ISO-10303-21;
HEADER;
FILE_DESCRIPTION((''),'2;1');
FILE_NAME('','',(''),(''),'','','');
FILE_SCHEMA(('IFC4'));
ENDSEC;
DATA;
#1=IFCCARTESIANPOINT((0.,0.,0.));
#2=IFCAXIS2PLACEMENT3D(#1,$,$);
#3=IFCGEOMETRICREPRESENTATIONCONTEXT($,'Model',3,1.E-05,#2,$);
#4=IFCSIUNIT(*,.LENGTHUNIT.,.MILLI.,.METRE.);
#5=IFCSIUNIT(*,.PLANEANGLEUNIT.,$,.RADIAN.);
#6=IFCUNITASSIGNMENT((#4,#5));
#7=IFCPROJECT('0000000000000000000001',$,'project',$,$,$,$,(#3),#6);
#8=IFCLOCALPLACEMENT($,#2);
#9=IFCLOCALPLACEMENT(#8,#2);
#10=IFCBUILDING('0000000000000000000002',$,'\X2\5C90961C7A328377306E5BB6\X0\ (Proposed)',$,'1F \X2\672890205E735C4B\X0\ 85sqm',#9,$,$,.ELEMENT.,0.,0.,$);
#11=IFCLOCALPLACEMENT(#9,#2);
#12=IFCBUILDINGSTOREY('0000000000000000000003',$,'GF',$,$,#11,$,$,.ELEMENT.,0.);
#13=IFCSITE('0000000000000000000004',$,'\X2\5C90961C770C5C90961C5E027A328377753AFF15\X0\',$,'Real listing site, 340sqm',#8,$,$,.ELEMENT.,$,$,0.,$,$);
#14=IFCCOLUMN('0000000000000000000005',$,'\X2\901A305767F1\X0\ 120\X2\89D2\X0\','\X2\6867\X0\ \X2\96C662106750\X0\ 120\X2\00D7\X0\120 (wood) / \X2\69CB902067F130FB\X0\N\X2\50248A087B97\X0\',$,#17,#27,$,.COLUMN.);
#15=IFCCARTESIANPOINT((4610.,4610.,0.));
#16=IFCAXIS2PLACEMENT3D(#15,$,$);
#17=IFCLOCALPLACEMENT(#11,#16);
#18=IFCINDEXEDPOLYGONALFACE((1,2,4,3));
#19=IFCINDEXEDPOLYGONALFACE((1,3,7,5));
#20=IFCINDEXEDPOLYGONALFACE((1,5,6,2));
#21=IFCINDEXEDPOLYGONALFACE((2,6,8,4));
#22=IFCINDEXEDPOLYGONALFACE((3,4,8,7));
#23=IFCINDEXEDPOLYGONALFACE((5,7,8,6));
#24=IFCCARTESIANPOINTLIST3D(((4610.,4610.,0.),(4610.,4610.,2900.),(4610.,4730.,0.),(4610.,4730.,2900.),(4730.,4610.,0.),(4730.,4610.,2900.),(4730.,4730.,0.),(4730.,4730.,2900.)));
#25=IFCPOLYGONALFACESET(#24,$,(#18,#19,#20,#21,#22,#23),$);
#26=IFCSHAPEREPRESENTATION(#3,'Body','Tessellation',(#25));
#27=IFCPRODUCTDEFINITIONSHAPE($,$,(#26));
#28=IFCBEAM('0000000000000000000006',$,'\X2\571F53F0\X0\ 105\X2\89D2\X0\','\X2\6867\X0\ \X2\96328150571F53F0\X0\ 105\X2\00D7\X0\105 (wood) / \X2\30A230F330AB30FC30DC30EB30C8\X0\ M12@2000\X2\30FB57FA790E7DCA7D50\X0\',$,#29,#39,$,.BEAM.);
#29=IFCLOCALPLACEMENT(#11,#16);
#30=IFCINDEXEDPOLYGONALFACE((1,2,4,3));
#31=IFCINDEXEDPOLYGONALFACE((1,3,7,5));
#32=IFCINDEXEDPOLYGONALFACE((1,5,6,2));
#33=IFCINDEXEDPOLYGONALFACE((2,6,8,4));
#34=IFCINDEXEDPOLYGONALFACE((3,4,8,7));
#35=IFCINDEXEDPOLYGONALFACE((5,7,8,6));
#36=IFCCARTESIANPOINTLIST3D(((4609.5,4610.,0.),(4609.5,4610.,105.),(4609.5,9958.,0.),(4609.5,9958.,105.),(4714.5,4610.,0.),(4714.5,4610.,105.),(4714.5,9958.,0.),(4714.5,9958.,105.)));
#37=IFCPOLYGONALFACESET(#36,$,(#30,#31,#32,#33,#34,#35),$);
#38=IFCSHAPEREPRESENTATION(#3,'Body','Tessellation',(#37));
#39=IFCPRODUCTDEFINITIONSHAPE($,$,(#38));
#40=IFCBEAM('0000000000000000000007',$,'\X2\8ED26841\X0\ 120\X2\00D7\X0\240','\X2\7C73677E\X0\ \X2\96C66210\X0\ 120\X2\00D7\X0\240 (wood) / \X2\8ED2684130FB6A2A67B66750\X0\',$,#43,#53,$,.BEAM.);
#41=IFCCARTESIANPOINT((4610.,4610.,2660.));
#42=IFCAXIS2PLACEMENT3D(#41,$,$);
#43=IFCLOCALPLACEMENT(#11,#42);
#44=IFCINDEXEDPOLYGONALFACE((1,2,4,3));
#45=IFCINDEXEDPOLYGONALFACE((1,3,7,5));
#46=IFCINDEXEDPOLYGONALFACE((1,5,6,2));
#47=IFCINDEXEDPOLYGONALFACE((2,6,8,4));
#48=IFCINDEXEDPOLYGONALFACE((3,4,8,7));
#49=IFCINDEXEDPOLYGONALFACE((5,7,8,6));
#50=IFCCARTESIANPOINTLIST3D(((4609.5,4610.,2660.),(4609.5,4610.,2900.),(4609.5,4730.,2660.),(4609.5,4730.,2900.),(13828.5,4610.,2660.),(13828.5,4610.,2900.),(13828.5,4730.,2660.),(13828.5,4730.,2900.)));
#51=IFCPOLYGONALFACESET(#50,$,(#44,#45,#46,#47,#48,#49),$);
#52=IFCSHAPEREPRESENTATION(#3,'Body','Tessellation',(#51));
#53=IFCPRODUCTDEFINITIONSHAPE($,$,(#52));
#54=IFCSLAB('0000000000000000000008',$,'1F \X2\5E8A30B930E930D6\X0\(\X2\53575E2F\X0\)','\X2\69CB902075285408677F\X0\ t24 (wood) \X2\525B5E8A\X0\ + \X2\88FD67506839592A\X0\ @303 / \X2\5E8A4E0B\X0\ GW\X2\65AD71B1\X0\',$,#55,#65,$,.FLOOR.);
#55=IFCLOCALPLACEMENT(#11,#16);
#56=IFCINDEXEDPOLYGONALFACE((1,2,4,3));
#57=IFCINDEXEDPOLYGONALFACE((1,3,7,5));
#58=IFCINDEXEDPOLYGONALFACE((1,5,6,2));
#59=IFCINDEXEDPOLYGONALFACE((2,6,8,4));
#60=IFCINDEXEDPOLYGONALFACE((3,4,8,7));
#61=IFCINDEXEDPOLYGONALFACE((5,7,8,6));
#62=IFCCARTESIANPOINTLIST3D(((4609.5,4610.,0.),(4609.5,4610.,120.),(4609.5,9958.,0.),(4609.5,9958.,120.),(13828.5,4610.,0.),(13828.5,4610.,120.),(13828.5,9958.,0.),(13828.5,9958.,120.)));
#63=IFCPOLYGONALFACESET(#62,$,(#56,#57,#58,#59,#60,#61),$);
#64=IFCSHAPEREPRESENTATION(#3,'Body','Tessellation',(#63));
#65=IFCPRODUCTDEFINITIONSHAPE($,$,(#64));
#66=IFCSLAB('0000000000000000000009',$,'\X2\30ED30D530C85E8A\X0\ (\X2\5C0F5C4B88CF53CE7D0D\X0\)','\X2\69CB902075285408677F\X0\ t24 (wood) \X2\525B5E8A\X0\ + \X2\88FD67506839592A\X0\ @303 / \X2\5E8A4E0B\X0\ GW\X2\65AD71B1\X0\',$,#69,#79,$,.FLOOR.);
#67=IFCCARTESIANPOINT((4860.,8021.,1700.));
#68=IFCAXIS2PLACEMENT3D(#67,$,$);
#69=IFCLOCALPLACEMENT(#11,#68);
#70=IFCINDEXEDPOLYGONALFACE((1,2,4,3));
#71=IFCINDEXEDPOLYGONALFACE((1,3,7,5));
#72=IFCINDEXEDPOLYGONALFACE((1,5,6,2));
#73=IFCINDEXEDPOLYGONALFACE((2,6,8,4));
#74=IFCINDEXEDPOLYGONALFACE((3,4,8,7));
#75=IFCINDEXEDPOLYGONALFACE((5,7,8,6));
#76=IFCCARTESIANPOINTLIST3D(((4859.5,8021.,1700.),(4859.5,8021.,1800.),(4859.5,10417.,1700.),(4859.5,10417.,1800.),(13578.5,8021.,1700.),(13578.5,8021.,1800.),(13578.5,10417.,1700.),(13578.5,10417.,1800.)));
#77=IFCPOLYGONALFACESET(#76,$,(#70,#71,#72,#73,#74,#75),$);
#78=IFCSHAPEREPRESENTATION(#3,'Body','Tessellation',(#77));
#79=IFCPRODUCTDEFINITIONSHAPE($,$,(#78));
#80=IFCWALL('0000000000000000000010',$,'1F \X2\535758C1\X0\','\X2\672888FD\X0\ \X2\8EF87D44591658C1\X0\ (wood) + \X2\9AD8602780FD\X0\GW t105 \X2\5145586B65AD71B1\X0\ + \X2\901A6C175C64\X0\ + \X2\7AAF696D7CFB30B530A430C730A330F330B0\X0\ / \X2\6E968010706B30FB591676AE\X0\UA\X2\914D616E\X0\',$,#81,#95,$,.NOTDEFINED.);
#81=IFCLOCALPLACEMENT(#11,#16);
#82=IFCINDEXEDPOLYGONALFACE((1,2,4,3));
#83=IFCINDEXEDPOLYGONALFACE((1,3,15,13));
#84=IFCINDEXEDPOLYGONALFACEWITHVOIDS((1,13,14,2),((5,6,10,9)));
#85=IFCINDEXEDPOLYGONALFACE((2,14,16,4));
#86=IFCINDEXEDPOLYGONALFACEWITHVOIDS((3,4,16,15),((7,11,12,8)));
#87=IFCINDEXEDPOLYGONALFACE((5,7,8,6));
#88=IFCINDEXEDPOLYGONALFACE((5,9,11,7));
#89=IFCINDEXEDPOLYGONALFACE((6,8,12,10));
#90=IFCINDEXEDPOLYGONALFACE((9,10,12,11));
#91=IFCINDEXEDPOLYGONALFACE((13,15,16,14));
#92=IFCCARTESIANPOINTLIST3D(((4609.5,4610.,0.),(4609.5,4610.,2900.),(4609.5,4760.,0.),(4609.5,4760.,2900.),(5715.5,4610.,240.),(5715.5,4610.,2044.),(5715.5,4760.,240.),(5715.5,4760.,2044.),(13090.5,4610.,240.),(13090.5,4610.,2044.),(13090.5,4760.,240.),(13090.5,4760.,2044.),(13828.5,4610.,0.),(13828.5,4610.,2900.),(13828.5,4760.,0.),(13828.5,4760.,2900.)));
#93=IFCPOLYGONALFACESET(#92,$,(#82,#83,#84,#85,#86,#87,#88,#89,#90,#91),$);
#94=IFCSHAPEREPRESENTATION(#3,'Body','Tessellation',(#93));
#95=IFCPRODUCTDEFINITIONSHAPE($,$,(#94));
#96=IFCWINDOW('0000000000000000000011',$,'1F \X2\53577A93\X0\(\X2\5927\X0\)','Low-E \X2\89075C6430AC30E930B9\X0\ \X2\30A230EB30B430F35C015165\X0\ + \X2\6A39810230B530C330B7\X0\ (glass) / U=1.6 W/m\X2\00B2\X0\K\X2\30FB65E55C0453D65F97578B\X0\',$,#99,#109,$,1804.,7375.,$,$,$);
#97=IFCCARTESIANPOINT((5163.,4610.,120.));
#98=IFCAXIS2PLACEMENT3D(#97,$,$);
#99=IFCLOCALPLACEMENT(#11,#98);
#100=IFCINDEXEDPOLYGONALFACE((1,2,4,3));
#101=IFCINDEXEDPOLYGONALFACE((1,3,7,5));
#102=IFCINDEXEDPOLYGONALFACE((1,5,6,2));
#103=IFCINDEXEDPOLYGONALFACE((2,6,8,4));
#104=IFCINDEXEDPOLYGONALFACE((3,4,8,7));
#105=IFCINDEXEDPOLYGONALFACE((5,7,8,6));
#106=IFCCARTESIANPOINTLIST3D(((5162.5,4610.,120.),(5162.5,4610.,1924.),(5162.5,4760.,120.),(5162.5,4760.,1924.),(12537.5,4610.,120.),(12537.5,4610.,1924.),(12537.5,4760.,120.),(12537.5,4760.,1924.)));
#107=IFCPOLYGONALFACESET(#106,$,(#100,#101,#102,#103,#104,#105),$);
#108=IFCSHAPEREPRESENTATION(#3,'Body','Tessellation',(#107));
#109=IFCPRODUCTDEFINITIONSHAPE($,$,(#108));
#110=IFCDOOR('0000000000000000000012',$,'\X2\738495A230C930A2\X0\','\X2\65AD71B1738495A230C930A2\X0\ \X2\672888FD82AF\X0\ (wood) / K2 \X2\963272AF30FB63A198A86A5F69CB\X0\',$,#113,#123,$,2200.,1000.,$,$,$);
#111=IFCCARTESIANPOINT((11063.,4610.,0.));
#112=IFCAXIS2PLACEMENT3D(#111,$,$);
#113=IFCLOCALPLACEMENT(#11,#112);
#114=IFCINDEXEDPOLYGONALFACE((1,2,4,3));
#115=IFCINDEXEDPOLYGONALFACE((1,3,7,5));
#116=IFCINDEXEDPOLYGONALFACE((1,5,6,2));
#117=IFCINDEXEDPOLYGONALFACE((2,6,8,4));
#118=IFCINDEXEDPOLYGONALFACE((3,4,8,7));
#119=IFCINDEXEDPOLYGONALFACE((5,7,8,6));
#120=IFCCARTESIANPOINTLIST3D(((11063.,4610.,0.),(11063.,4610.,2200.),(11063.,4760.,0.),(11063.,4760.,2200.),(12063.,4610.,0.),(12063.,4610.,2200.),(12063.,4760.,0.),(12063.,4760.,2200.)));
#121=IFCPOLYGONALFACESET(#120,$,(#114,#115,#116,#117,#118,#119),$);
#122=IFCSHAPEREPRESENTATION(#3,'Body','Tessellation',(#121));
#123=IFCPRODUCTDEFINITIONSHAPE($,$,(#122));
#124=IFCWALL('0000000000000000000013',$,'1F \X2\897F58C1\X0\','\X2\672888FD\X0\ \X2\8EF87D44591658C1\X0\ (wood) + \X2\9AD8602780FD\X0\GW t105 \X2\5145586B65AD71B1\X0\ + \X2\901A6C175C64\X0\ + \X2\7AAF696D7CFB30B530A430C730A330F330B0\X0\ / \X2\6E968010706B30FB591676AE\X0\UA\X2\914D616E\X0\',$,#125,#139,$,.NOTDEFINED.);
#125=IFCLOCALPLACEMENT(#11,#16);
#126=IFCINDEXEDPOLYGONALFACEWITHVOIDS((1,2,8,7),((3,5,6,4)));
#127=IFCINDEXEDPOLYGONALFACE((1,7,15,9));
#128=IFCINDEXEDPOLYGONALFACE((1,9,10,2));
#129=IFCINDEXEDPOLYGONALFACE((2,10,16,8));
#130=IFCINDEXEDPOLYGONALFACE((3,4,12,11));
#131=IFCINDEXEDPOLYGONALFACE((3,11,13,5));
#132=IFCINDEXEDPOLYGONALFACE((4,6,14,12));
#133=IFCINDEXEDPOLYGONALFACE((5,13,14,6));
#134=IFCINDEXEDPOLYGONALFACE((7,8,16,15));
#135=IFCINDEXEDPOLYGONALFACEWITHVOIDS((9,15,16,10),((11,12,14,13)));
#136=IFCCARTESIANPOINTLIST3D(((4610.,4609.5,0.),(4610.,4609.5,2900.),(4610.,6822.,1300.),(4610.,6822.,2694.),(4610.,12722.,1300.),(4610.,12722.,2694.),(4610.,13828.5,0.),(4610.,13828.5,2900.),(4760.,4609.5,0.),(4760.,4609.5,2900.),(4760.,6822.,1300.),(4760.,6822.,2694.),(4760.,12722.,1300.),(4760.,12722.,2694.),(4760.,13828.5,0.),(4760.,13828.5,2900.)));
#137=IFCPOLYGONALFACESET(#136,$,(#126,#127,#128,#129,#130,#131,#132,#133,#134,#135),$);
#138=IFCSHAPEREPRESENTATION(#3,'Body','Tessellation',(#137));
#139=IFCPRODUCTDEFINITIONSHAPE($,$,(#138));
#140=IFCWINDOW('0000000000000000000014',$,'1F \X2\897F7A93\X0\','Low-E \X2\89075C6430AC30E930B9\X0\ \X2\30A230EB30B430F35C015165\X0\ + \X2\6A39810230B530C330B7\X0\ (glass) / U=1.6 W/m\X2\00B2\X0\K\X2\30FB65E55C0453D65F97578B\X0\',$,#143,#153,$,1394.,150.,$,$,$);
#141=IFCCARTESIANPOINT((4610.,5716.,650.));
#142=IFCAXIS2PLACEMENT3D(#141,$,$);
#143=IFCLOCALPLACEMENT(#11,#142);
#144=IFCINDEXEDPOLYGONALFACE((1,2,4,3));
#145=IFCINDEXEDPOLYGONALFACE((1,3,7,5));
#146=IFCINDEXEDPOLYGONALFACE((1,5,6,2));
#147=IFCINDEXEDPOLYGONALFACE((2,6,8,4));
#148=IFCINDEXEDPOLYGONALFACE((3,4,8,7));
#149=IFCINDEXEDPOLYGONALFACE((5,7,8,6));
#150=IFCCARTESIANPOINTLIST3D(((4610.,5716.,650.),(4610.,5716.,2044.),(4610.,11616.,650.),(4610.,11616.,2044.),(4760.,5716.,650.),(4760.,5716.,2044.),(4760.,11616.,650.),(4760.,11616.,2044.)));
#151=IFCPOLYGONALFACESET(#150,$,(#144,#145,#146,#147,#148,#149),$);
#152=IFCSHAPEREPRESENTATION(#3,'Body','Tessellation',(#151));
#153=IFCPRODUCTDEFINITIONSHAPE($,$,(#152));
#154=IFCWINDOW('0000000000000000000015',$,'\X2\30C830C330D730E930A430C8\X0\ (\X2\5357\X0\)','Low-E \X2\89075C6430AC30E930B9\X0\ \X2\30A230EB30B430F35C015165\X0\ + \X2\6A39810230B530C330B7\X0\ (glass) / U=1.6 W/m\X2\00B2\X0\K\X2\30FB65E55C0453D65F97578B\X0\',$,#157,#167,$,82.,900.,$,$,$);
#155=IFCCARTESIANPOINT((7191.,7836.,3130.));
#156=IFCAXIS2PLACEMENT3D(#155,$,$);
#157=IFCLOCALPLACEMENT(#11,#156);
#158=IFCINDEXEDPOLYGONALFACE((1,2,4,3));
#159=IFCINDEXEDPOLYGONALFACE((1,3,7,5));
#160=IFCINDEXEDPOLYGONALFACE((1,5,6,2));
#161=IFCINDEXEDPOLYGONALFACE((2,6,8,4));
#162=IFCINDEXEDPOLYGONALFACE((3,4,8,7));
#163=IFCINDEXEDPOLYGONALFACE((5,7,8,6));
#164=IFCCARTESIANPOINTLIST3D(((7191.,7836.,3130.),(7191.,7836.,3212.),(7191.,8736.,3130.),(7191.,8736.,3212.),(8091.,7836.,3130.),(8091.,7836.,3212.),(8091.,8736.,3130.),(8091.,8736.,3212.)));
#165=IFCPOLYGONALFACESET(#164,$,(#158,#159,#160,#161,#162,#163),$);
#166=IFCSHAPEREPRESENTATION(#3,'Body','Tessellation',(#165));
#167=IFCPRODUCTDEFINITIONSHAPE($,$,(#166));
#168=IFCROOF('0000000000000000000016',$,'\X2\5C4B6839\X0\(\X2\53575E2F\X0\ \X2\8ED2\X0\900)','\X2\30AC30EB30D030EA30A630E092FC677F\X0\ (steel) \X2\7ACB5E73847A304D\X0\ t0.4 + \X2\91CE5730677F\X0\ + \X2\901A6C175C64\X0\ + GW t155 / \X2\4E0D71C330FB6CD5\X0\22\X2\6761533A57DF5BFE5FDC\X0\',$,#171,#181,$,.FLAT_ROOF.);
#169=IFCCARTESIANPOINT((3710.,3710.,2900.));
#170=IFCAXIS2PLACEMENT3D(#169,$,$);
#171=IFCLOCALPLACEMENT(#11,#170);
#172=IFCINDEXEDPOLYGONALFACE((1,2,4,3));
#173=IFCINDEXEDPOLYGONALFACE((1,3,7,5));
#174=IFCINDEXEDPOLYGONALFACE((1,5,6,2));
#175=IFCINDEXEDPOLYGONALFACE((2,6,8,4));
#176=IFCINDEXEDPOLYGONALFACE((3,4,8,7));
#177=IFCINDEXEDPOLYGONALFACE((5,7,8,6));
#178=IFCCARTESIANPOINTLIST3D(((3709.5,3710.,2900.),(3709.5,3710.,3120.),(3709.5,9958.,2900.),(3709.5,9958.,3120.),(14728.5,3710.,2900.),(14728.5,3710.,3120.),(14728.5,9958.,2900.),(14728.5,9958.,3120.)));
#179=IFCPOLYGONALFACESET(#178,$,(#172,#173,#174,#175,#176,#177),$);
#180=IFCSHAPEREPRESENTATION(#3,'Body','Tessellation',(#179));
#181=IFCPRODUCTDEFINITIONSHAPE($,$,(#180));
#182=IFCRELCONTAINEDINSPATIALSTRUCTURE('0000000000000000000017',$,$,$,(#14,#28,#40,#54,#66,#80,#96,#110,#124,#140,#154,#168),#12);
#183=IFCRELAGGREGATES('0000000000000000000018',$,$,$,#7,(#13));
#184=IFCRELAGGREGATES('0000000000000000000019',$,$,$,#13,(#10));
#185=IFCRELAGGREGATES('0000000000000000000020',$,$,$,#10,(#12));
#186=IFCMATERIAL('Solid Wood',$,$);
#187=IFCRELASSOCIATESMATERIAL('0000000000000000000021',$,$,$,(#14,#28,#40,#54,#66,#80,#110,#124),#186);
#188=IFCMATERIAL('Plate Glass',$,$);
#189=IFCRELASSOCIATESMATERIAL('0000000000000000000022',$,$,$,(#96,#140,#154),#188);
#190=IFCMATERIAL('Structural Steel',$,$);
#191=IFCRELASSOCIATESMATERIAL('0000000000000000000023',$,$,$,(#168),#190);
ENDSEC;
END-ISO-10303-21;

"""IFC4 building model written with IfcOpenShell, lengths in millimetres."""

from ifc_helpers import new_model, si_unit, frame, frame_2d, origin, place, context, project, spatial, rectangle, extrude, material, element, fill, save


model = new_model("IFC4")

# Units and contexts
model_context = context("Model", 3, precision=1e-05, world=origin())
ifc_project = project(units=[si_unit("LENGTHUNIT", "METRE", prefix="MILLI"), si_unit("PLANEANGLEUNIT", "RADIAN")], contexts=[model_context])

# Site, building, storey
site_placement = place(None, origin())
site = spatial("IfcSite", under=ifc_project, at=site_placement, Name="岐阜県岐阜市稲荷町５", ObjectType="Real listing site, 340sqm", CompositionType="ELEMENT", RefElevation=0.0)
building_placement = place(site_placement, origin())
building = spatial("IfcBuilding", under=site, at=building_placement, Name="岐阜稲荷の家 (Proposed)", ObjectType="1F 木造平屋 85sqm", CompositionType="ELEMENT", ElevationOfRefHeight=0.0, ElevationOfTerrain=0.0)
storey_placement = place(building_placement, origin())
storey = spatial("IfcBuildingStorey", under=building, at=storey_placement, Name="GF", CompositionType="ELEMENT", Elevation=0.0)

# Column
ifc_material_1 = material(Name="Solid Wood")
column_1_placement = place(storey_placement, frame((4610.0, 4610.0, 0.0)))
element("IfcColumn", 1, at=column_1_placement, inside=storey, material=ifc_material_1, Name="通し柱 120角", Description="桧 集成材 120×120 (wood) / 構造柱・N値計算", PredefinedType="COLUMN", context=model_context, shape_type="SweptSolid", body=[
    extrude(rectangle(XDim=120.0, YDim=120.0, at=frame_2d((60.0, 60.0))), frame((4610.0, 4610.0, 0.0)), (0.0, 0.0, 1.0), 2900.0),
])

# Beams
beam_1_placement = place(storey_placement, frame((4610.0, 4610.0, 0.0)))
element("IfcBeam", 2, at=beam_1_placement, inside=storey, material=ifc_material_1, Name="土台 105角", Description="桧 防腐土台 105×105 (wood) / アンカーボルト M12@2000・基礎緊結", PredefinedType="BEAM", context=model_context, shape_type="SweptSolid", body=[
    extrude(rectangle(XDim=105.0, YDim=5348.0, at=frame_2d((52.0, 2674.0))), frame((4610.0, 4610.0, 0.0)), (0.0, 0.0, 1.0), 105.0),
])
beam_2_placement = place(storey_placement, frame((4610.0, 4610.0, 2660.0)))
element("IfcBeam", 3, at=beam_2_placement, inside=storey, material=ifc_material_1, Name="軒桁 120×240", Description="米松 集成 120×240 (wood) / 軒桁・横架材", PredefinedType="BEAM", context=model_context, shape_type="SweptSolid", body=[
    extrude(rectangle(XDim=9219.0, YDim=120.0, at=frame_2d((4609.0, 60.0))), frame((4610.0, 4610.0, 2660.0)), (0.0, 0.0, 1.0), 240.0),
])

# Slabs
slab_1_placement = place(storey_placement, frame((4610.0, 4610.0, 0.0)))
element("IfcSlab", 4, at=slab_1_placement, inside=storey, material=ifc_material_1, Name="1F 床スラブ(南帯)", Description="構造用合板 t24 (wood) 剛床 + 製材根太 @303 / 床下 GW断熱", PredefinedType="FLOOR", context=model_context, shape_type="SweptSolid", body=[
    extrude(rectangle(XDim=9219.0, YDim=5348.0, at=frame_2d((4609.0, 2674.0))), frame((4610.0, 4610.0, 0.0)), (0.0, 0.0, 1.0), 120.0),
])
slab_2_placement = place(storey_placement, frame((4860.0, 8021.0, 1700.0)))
element("IfcSlab", 5, at=slab_2_placement, inside=storey, material=ifc_material_1, Name="ロフト床 (小屋裏収納)", Description="構造用合板 t24 (wood) 剛床 + 製材根太 @303 / 床下 GW断熱", PredefinedType="FLOOR", context=model_context, shape_type="SweptSolid", body=[
    extrude(rectangle(XDim=8719.0, YDim=2396.0, at=frame_2d((4359.0, 1198.0))), frame((4860.0, 8021.0, 1700.0)), (0.0, 0.0, 1.0), 100.0),
])

# Wall, openings, window, door
wall_1_placement = place(storey_placement, frame((4610.0, 4610.0, 0.0)))
wall_1 = element("IfcWall", 6, at=wall_1_placement, inside=storey, material=ifc_material_1, Name="1F 南壁", Description="木製 軸組外壁 (wood) + 高性能GW t105 充填断熱 + 通気層 + 窯業系サイディング / 準耐火・外皮UA配慮", PredefinedType="NOTDEFINED", context=model_context, shape_type="SweptSolid", body=[
    extrude(rectangle(XDim=9219.0, YDim=150.0, at=frame_2d((4609.0, 75.0))), frame((4610.0, 4610.0, 0.0)), (0.0, 0.0, 1.0), 2900.0),
])
opening_1_placement = place(storey_placement, frame((5163.0, 4610.0, 120.0)))
opening_1 = element("IfcOpeningElement", 7, at=opening_1_placement, cuts=wall_1, PredefinedType="NOTDEFINED", context=model_context, shape_type="SweptSolid", body=[
    extrude(rectangle(XDim=7375.0, YDim=150.0, at=frame_2d((3687.0, 75.0))), frame((5163.0, 4610.0, 120.0)), (0.0, 0.0, 1.0), 1804.0),
])
opening_2_placement = place(storey_placement, frame((11063.0, 4610.0, 0.0)))
opening_2 = element("IfcOpeningElement", 8, at=opening_2_placement, cuts=wall_1, PredefinedType="NOTDEFINED", context=model_context, shape_type="SweptSolid", body=[
    extrude(rectangle(XDim=1000.0, YDim=150.0, at=frame_2d((500.0, 75.0))), frame((11063.0, 4610.0, 0.0)), (0.0, 0.0, 1.0), 2200.0),
])
ifc_material_2 = material(Name="Plate Glass")
window_1_placement = place(storey_placement, frame((5163.0, 4610.0, 120.0)))
window_1 = element("IfcWindow", 9, at=window_1_placement, inside=storey, material=ifc_material_2, Name="1F 南窓(大)", Description="Low-E 複層ガラス アルゴン封入 + 樹脂サッシ (glass) / U=1.6 W/m²K・日射取得型", OverallHeight=1804.0, OverallWidth=7375.0, context=model_context, shape_type="SweptSolid", body=[
    extrude(rectangle(XDim=7375.0, YDim=150.0, at=frame_2d((3687.0, 75.0))), frame((5163.0, 4610.0, 120.0)), (0.0, 0.0, 1.0), 1804.0),
])
fill(opening_1, window_1)
door_1_placement = place(storey_placement, frame((11063.0, 4610.0, 0.0)))
door_1 = element("IfcDoor", 10, at=door_1_placement, inside=storey, material=ifc_material_1, Name="玄関ドア", Description="断熱玄関ドア 木製芯 (wood) / K2 防犯・採風機構", OverallHeight=2200.0, OverallWidth=1000.0, context=model_context, shape_type="SweptSolid", body=[
    extrude(rectangle(XDim=1000.0, YDim=150.0, at=frame_2d((500.0, 75.0))), frame((11063.0, 4610.0, 0.0)), (0.0, 0.0, 1.0), 2200.0),
])
fill(opening_2, door_1)

# Wall, opening, window
wall_2_placement = place(storey_placement, frame((4610.0, 4610.0, 0.0)))
wall_2 = element("IfcWall", 11, at=wall_2_placement, inside=storey, material=ifc_material_1, Name="1F 西壁", Description="木製 軸組外壁 (wood) + 高性能GW t105 充填断熱 + 通気層 + 窯業系サイディング / 準耐火・外皮UA配慮", PredefinedType="NOTDEFINED", context=model_context, shape_type="SweptSolid", body=[
    extrude(rectangle(XDim=150.0, YDim=9219.0, at=frame_2d((75.0, 4609.0))), frame((4610.0, 4610.0, 0.0)), (0.0, 0.0, 1.0), 2900.0),
])
opening_3_placement = place(storey_placement, frame((4610.0, 5716.0, 650.0)))
opening_3 = element("IfcOpeningElement", 12, at=opening_3_placement, cuts=wall_2, PredefinedType="NOTDEFINED", context=model_context, shape_type="SweptSolid", body=[
    extrude(rectangle(XDim=150.0, YDim=5900.0, at=frame_2d((75.0, 2950.0))), frame((4610.0, 5716.0, 650.0)), (0.0, 0.0, 1.0), 1394.0),
])
window_2_placement = place(storey_placement, frame((4610.0, 5716.0, 650.0)))
window_2 = element("IfcWindow", 13, at=window_2_placement, inside=storey, material=ifc_material_2, Name="1F 西窓", Description="Low-E 複層ガラス アルゴン封入 + 樹脂サッシ (glass) / U=1.6 W/m²K・日射取得型", OverallHeight=1394.0, OverallWidth=150.0, context=model_context, shape_type="SweptSolid", body=[
    extrude(rectangle(XDim=150.0, YDim=5900.0, at=frame_2d((75.0, 2950.0))), frame((4610.0, 5716.0, 650.0)), (0.0, 0.0, 1.0), 1394.0),
])
fill(opening_3, window_2)

# Window
window_3_placement = place(storey_placement, frame((7191.0, 7836.0, 3130.0)))
element("IfcWindow", 14, at=window_3_placement, inside=storey, material=ifc_material_2, Name="トップライト (南)", Description="Low-E 複層ガラス アルゴン封入 + 樹脂サッシ (glass) / U=1.6 W/m²K・日射取得型", OverallHeight=82.0, OverallWidth=900.0, context=model_context, shape_type="SweptSolid", body=[
    extrude(rectangle(XDim=900.0, YDim=900.0, at=frame_2d((450.0, 450.0))), frame((7191.0, 7836.0, 3130.0)), (0.0, 0.0, 1.0), 82.0),
])

# Roof
ifc_material_3 = material(Name="Structural Steel")
roof_placement = place(storey_placement, frame((3710.0, 3710.0, 2900.0)))
element("IfcRoof", 15, at=roof_placement, inside=storey, material=ifc_material_3, Name="屋根(南帯 軒900)", Description="ガルバリウム鋼板 (steel) 立平葺き t0.4 + 野地板 + 通気層 + GW t155 / 不燃・法22条区域対応", PredefinedType="FLAT_ROOF", context=model_context, shape_type="SweptSolid", body=[
    extrude(rectangle(XDim=11019.0, YDim=6248.0, at=frame_2d((5509.0, 3124.0))), frame((3710.0, 3710.0, 2900.0)), (0.0, 0.0, 1.0), 220.0),
])

save(model, "model.ifc")
